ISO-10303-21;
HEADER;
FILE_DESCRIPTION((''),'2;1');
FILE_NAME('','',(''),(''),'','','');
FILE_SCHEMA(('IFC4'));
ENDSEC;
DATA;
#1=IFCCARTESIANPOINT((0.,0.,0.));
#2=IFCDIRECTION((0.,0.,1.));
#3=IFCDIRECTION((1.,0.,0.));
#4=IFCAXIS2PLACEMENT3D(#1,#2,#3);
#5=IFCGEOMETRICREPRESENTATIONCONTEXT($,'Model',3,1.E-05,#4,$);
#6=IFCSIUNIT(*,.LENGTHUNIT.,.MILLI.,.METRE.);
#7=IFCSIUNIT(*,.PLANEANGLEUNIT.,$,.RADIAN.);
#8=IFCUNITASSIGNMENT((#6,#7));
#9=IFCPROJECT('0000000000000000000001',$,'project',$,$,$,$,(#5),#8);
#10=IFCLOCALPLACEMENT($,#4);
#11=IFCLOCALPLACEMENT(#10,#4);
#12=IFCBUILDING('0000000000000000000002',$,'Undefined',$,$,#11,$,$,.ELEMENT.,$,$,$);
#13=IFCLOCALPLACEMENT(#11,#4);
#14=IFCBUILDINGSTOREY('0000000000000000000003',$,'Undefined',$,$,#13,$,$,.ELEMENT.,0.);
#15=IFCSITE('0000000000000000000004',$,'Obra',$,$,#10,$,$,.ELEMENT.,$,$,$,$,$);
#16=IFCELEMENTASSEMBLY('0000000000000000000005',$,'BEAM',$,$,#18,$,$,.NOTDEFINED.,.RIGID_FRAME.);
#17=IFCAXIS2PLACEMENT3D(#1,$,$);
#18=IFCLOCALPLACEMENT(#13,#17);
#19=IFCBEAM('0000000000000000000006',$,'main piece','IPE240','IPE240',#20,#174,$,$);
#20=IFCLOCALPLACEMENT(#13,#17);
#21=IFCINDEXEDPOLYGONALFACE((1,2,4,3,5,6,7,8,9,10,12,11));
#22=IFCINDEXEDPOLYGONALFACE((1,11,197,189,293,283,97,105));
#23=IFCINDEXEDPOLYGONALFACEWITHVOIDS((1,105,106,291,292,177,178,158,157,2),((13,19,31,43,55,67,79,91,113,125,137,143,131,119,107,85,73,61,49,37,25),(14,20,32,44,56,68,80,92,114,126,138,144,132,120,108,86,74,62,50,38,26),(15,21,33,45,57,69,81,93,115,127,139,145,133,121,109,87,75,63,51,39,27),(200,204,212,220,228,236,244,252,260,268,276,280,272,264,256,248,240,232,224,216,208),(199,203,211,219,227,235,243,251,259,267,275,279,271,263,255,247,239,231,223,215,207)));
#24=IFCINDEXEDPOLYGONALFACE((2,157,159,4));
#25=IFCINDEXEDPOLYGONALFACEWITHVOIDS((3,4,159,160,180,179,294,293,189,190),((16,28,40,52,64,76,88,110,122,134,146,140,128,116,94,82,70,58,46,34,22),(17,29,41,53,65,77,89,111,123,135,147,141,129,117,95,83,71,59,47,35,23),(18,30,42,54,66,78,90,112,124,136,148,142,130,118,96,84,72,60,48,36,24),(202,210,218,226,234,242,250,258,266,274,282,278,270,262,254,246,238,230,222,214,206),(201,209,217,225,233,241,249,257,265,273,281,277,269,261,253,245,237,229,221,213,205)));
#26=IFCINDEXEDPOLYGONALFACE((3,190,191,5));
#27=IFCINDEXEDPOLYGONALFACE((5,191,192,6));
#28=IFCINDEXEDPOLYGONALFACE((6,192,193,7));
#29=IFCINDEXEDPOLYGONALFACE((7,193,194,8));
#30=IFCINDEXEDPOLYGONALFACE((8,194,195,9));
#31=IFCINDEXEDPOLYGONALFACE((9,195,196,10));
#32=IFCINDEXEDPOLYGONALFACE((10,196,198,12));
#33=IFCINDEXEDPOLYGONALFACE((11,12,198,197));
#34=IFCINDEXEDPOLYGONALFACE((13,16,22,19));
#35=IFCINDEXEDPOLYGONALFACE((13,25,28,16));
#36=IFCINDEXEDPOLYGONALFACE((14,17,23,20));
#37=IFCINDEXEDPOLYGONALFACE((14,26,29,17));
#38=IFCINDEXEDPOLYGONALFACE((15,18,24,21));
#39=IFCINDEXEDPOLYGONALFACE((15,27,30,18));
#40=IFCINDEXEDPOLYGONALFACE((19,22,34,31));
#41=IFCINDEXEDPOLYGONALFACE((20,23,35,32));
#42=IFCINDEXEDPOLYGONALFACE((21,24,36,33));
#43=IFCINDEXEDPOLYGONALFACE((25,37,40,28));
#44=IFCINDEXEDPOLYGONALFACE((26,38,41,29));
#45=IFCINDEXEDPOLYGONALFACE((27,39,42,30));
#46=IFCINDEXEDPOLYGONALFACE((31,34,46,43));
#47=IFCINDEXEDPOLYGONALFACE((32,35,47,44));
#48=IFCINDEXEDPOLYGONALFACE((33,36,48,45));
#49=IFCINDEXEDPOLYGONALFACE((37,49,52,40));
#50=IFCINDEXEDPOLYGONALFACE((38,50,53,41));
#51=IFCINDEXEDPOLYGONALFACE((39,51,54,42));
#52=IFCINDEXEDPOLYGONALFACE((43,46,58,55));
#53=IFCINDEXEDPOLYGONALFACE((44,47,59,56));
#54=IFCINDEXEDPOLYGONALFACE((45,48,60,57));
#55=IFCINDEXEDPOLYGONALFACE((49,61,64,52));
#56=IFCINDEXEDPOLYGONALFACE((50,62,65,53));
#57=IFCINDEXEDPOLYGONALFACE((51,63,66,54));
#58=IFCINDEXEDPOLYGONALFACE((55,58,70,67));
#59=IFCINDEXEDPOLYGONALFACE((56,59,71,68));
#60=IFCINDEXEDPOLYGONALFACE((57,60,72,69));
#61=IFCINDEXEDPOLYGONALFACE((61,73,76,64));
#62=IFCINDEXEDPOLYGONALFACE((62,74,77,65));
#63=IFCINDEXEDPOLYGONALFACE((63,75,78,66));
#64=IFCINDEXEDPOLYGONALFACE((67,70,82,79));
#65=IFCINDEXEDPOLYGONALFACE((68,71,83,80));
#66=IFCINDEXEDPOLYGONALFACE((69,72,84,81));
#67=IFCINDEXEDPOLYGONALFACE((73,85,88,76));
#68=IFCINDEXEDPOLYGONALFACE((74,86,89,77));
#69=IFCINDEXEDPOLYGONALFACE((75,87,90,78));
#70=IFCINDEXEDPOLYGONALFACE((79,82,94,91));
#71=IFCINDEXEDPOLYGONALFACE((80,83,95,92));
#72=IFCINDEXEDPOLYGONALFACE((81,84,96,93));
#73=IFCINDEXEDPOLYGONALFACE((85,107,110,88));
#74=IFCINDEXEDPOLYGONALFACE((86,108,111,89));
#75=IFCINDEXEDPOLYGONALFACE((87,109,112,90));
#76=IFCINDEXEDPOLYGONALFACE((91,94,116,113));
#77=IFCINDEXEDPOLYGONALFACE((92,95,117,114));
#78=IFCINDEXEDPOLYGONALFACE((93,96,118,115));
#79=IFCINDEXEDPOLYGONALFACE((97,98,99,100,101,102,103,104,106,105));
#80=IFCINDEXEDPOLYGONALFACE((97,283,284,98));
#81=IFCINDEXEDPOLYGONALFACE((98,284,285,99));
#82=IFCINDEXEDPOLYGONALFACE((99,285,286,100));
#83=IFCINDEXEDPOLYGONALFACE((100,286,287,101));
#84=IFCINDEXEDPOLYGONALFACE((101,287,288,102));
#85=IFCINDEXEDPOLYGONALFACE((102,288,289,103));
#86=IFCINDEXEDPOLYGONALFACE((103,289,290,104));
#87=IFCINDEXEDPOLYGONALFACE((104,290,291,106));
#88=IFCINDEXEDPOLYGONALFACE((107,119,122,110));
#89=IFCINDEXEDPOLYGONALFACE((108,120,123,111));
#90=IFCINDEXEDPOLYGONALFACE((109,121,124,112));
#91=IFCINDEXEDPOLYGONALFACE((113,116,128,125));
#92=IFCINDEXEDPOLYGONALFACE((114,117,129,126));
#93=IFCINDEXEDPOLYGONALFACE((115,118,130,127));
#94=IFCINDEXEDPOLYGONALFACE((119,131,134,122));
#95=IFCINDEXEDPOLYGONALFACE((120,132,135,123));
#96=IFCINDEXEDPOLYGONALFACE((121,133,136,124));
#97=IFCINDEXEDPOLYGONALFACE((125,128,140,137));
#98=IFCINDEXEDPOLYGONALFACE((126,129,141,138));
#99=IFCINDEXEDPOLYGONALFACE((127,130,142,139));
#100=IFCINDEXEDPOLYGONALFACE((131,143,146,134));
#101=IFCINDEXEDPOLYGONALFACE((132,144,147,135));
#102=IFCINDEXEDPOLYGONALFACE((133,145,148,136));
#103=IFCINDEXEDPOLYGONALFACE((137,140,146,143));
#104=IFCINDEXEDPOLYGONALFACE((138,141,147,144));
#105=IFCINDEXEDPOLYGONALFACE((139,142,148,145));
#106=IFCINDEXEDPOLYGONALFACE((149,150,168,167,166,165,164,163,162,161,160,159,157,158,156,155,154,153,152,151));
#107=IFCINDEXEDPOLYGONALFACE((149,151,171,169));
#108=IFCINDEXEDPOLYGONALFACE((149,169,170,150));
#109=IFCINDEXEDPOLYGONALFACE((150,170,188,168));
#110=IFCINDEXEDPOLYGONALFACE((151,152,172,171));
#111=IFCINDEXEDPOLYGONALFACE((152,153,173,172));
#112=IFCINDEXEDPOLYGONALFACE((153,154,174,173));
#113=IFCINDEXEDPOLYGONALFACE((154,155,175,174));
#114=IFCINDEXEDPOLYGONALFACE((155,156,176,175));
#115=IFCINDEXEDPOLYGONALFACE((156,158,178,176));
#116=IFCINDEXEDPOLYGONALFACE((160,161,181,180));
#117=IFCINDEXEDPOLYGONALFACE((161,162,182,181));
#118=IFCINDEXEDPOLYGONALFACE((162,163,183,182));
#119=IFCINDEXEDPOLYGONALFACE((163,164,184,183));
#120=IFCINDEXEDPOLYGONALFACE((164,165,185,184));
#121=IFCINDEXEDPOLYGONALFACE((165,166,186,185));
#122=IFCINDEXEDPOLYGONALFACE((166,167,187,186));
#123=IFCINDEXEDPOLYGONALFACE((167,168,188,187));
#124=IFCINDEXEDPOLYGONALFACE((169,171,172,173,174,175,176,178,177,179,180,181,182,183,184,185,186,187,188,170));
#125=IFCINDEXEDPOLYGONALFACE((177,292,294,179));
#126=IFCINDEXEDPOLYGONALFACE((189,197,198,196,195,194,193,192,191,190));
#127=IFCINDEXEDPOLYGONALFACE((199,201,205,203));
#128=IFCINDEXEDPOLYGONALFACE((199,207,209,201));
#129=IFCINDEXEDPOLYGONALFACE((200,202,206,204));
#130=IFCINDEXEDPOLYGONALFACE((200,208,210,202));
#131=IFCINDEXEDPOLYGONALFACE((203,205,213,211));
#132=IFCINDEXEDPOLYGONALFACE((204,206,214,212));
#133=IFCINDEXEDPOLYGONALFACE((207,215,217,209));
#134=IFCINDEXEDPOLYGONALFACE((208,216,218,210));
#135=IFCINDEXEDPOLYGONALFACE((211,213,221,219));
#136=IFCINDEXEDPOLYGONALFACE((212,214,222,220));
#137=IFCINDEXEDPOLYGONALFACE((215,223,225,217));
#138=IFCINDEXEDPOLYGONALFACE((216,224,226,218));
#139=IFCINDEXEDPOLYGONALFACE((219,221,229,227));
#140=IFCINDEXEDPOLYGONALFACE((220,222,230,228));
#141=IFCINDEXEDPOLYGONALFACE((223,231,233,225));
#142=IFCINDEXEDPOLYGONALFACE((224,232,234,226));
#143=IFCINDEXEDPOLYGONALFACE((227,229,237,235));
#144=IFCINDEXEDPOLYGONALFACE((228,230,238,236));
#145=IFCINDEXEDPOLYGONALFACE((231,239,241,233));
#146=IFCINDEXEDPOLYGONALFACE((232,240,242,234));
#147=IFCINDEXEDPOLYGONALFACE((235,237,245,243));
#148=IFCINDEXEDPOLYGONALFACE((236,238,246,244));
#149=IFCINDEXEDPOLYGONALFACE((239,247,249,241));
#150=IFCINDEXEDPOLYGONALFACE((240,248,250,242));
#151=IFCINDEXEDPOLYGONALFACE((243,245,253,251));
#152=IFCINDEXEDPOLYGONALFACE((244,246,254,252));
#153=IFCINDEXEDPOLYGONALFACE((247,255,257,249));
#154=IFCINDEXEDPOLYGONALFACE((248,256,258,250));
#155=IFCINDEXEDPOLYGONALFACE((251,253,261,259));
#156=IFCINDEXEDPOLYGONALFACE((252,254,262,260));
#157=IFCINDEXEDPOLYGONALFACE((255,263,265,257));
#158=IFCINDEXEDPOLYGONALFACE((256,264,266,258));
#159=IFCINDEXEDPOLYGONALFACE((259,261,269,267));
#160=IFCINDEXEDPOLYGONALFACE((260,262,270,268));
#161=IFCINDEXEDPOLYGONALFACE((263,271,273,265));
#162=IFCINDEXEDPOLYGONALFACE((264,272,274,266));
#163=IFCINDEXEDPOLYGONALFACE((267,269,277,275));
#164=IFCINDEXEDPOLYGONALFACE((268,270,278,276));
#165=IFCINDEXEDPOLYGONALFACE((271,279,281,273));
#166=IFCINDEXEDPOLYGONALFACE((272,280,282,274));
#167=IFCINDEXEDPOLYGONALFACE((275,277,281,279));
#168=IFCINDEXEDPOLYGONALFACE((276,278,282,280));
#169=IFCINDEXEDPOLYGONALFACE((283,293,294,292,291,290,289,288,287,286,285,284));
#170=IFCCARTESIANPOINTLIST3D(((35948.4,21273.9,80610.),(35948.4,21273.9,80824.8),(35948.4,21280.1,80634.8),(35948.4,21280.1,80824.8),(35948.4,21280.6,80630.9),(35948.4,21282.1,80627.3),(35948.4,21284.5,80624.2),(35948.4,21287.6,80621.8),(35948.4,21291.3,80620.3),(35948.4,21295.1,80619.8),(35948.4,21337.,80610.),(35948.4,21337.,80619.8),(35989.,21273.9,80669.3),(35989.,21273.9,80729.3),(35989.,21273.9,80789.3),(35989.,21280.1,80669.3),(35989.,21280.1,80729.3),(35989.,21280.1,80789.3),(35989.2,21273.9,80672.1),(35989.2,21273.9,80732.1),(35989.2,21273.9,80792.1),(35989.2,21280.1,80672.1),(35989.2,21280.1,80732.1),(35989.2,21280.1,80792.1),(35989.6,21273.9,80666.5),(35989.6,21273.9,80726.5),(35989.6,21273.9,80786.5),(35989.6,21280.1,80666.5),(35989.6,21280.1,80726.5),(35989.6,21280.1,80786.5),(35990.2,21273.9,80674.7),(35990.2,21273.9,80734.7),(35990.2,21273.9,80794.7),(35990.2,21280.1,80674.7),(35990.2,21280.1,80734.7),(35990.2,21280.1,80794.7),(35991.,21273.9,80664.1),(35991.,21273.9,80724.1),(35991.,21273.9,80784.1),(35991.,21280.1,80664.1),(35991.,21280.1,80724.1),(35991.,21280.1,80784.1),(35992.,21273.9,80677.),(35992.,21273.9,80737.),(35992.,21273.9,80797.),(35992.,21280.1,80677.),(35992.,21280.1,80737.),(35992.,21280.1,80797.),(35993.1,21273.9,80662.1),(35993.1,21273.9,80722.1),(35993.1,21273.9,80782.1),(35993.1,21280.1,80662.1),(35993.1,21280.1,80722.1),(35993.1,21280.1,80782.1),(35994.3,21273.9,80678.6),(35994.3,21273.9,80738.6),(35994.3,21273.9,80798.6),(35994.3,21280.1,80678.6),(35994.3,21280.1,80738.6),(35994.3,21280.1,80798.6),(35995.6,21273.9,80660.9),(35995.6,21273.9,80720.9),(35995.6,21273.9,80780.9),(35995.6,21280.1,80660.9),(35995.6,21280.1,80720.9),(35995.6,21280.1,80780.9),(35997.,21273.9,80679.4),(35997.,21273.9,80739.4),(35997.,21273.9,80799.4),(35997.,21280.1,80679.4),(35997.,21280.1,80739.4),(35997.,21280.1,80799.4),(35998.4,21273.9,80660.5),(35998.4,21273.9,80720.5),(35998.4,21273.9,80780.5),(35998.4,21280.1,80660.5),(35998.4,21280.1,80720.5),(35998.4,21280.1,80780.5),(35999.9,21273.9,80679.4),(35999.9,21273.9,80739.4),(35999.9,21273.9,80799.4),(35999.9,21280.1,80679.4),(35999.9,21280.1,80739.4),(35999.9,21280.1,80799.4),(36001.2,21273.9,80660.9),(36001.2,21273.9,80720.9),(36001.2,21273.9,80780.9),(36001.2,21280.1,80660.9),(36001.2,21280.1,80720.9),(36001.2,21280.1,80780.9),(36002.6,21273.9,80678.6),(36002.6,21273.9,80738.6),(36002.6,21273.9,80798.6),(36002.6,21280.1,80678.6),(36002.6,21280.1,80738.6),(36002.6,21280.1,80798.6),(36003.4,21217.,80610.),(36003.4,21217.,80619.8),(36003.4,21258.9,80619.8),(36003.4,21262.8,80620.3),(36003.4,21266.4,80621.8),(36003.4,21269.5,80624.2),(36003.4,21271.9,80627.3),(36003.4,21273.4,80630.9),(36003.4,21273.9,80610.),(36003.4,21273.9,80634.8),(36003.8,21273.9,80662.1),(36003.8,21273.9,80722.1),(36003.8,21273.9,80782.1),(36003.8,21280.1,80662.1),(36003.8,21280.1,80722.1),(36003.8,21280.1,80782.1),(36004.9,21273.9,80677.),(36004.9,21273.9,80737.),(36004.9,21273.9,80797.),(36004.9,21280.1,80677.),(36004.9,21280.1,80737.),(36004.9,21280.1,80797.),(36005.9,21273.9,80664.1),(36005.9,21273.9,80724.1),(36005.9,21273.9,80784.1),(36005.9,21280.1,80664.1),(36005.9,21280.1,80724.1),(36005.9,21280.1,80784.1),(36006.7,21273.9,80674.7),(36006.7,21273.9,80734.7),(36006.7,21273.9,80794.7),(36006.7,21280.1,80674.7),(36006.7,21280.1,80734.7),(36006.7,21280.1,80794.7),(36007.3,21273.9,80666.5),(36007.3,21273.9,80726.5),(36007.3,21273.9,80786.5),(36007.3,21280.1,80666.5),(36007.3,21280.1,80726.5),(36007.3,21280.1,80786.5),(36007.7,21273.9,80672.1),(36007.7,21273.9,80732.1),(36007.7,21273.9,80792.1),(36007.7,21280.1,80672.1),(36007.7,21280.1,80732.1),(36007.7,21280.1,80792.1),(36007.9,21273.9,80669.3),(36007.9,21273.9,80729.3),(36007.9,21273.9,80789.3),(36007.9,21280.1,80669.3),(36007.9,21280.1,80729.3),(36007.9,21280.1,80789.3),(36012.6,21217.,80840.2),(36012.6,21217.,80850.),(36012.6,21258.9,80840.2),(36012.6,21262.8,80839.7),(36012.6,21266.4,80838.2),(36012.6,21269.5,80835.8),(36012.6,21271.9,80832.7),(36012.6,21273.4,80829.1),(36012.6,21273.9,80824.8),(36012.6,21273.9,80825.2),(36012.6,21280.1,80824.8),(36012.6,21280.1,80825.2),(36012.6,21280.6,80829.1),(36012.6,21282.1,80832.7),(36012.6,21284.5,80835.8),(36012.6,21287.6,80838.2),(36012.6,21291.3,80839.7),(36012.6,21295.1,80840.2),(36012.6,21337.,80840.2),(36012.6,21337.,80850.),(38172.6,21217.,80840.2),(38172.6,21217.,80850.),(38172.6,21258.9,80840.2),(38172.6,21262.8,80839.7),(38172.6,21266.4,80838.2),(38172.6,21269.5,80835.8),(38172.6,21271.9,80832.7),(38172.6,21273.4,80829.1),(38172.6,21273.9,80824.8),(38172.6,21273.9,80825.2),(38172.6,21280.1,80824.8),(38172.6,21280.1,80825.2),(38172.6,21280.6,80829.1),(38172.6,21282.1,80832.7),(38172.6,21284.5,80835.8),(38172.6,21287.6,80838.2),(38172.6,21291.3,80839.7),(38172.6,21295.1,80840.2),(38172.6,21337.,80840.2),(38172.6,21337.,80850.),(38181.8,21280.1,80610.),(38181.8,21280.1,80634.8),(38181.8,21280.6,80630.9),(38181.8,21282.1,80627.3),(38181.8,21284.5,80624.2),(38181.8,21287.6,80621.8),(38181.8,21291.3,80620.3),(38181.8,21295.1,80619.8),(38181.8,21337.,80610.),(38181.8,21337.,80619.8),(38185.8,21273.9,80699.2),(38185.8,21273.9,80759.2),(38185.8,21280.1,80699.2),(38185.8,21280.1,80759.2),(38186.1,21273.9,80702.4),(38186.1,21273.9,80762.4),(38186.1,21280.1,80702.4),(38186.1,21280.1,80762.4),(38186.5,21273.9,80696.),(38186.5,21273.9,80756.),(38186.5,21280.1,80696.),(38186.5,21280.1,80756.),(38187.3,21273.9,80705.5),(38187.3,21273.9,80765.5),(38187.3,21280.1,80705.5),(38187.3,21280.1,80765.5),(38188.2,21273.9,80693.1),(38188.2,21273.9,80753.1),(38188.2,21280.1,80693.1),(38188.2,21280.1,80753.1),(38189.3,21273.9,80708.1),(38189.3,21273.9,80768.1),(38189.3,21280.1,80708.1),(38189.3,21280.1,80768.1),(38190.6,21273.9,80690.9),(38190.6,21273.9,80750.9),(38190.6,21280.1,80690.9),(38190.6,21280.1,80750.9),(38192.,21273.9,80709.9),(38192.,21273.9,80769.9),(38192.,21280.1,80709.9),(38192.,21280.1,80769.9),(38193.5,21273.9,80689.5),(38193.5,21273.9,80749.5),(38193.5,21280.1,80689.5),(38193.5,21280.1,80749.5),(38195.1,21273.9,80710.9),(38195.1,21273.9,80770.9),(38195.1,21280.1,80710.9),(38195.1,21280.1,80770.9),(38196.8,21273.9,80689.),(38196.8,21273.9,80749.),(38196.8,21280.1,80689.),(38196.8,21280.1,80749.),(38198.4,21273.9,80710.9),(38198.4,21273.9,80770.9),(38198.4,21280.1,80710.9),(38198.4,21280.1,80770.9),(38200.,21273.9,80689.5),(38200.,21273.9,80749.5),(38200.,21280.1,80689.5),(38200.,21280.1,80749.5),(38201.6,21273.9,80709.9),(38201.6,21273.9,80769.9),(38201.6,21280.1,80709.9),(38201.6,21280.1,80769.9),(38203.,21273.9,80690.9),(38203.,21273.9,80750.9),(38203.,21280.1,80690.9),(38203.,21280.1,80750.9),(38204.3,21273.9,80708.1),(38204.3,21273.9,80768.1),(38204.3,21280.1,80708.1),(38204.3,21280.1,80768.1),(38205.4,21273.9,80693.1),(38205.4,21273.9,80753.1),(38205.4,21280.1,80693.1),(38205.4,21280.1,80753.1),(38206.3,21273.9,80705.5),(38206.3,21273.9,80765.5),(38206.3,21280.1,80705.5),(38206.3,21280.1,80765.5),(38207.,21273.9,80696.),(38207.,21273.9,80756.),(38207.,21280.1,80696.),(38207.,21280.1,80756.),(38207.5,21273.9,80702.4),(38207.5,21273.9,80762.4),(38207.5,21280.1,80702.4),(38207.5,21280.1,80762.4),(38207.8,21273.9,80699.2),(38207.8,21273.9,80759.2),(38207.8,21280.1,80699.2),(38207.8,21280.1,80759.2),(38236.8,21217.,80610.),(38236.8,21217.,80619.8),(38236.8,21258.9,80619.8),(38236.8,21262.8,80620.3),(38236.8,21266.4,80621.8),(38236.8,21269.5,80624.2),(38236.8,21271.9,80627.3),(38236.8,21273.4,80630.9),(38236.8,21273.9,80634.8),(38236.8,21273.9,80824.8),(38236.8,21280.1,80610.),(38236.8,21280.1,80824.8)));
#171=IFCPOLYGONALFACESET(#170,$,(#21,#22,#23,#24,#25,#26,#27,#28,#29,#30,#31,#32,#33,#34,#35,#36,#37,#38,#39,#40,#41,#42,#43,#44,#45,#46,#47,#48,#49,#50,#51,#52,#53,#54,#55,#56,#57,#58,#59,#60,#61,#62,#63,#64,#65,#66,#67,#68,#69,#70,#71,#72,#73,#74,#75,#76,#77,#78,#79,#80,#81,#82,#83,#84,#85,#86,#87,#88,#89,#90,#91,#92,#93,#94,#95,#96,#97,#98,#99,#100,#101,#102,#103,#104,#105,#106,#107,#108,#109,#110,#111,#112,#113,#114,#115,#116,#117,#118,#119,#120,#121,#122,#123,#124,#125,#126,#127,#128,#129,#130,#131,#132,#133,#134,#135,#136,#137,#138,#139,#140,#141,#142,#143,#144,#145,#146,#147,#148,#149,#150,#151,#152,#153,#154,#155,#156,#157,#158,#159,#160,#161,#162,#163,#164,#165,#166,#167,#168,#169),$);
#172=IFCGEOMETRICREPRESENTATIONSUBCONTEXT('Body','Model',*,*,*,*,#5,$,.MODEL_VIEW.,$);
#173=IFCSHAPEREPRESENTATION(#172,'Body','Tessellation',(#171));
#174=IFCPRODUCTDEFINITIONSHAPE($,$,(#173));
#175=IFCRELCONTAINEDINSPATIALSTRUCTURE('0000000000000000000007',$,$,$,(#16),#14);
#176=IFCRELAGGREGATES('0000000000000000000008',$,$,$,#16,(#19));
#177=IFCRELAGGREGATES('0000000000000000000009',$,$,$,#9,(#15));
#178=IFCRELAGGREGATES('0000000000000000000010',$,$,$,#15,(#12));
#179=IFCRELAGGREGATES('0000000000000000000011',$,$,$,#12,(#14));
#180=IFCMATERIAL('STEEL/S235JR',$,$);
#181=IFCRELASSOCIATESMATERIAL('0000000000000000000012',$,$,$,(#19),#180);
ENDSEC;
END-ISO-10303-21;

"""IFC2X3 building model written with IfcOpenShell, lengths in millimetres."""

from ifc_helpers import new_model, si_unit, frame, origin_with_axes, origin_2d_with_axis, place, context, subcontext, project, spatial, rectangle, circle, i_section, extrude, clip, halfspace, source, transform, mapped, material, element, aggregate, save


model = new_model("IFC2X3")

# Units and contexts
model_context = context("Model", 3, precision=1e-05, world=origin_with_axes())
body_context = subcontext(model_context, "Body", "Model", "MODEL_VIEW")
ifc_project = project(units=[si_unit("LENGTHUNIT", "METRE", prefix="MILLI"), si_unit("PLANEANGLEUNIT", "RADIAN")], contexts=[model_context])

# Site, building, storey
site_placement = place(None, origin_with_axes())
site = spatial("IfcSite", under=ifc_project, at=site_placement, Name="Obra", CompositionType="ELEMENT")
building_placement = place(site_placement, origin_with_axes())
building = spatial("IfcBuilding", under=site, at=building_placement, Name="Undefined", CompositionType="ELEMENT")
storey_placement = place(building_placement, origin_with_axes())
storey = spatial("IfcBuildingStorey", under=building, at=storey_placement, Name="Undefined", CompositionType="ELEMENT", Elevation=0.0)

# Element assembly, beam, openings
assembly_1_placement = place(storey_placement, origin_with_axes())
assembly_1 = element("IfcElementAssembly", 1, at=assembly_1_placement, inside=storey, Name="BEAM", AssemblyPlace="NOTDEFINED", PredefinedType="RIGID_FRAME")
ifc_material_1 = material(Name="STEEL/S235JR")
beam_1_placement = place(assembly_1_placement, frame((36015.4, 21277.0, 80730.0), z_axis=(0.0, 0.0, 1.0), x_axis=(1.0, 0.0, 0.0)))
beam_1 = element("IfcBeam", 2, at=beam_1_placement, material=ifc_material_1, Name="main piece", Description="IPE240", ObjectType="IPE240", context=body_context, shape_type="Clipping", body=[
    clip(clip(extrude(i_section(OverallWidth=120.0, OverallDepth=240.0, WebThickness=6.2, FlangeThickness=9.8, FilletRadius=15.0, at=origin_2d_with_axis()), frame((2221.4, 0.0, 0.0), z_axis=(-1.0, 0.0, 0.0), x_axis=(0.0, -1.0, 0.0)), (0.0, 0.0, 1.0), 2288.3), halfspace(frame((2221.4, 0.0, -220.0), z_axis=(-1.0, 0.0, 0.0), x_axis=(0.0, 1.0, 0.0)), True)), halfspace(frame((-66.9, 0.0, -220.0), z_axis=(1.0, 0.0, 0.0), x_axis=(0.0, -1.0, 0.0)), True)),
])
opening_1_placement = place(assembly_1_placement, frame((36015.4, 21277.0, 80730.0), z_axis=(0.0, 0.0, 1.0), x_axis=(1.0, 0.0, 0.0)))
element("IfcOpeningElement", 3, at=opening_1_placement, cuts=beam_1, ObjectType="Recess", context=body_context, shape_type="SweptSolid", body=[
    extrude(rectangle(XDim=65.0, YDim=300.0, at=origin_2d_with_axis()), frame((2198.9, 153.1, 109.8), z_axis=(0.0, 0.0, -1.0), x_axis=(-1.0, 0.0, 0.0)), (0.0, 0.0, 1.0), 249.6),
])
opening_2_placement = place(assembly_1_placement, frame((36015.4, 21277.0, 80730.0), z_axis=(0.0, 0.0, 1.0), x_axis=(1.0, 0.0, 0.0)))
element("IfcOpeningElement", 4, at=opening_2_placement, cuts=beam_1, ObjectType="Recess", context=body_context, shape_type="SweptSolid", body=[
    extrude(rectangle(XDim=26.2, YDim=76.2, at=origin_2d_with_axis()), frame((2195.3, 61.0, 107.9), z_axis=(0.0, -1.0, 0.0), x_axis=(0.0, 0.0, -1.0)), (0.0, 0.0, 1.0), 122.0),
])
opening_3_placement = place(assembly_1_placement, frame((36015.4, 21277.0, 80730.0), z_axis=(0.0, 0.0, 1.0), x_axis=(1.0, 0.0, 0.0)))
element("IfcOpeningElement", 5, at=opening_3_placement, cuts=beam_1, ObjectType="Recess", context=body_context, shape_type="SweptSolid", body=[
    extrude(rectangle(XDim=65.0, YDim=300.0, at=origin_2d_with_axis()), frame((-44.4, -153.1, 109.8), z_axis=(0.0, 0.0, -1.0), x_axis=(1.0, 0.0, 0.0)), (0.0, 0.0, 1.0), 249.6),
])
opening_4_placement = place(assembly_1_placement, frame((36015.4, 21277.0, 80730.0), z_axis=(0.0, 0.0, 1.0), x_axis=(1.0, 0.0, 0.0)))
element("IfcOpeningElement", 6, at=opening_4_placement, cuts=beam_1, ObjectType="Recess", context=body_context, shape_type="SweptSolid", body=[
    extrude(rectangle(XDim=26.2, YDim=76.2, at=origin_2d_with_axis()), frame((-40.8, -61.0, 107.9), z_axis=(0.0, 1.0, 0.0), x_axis=(0.0, 0.0, -1.0)), (0.0, 0.0, 1.0), 122.0),
])
shared_shape_1 = source(origin_with_axes(), body_context, "Body", "SweptSolid", [
    extrude(circle(Radius=11.0, at=origin_2d_with_axis()), frame((0.0, -3.2, 0.0), z_axis=(0.0, 1.0, 0.0), x_axis=(1.0, 0.0, 0.0)), (0.0, 0.0, 1.0), 6.4),
])
opening_5_placement = place(assembly_1_placement, frame((38236.8, 21277.0, 80850.0), z_axis=(-1.0, 0.0, 0.0), x_axis=(0.0, 0.0, -1.0)))
element("IfcOpeningElement", 7, at=opening_5_placement, cuts=beam_1, ObjectType="Opening", context=body_context, shape_type="MappedRepresentation", body=[
    mapped(shared_shape_1, transform((90.0, 0.0, 40.0))),
    mapped(shared_shape_1, transform((150.0, 0.0, 40.0))),
])
shared_shape_2 = source(origin_with_axes(), body_context, "Body", "SweptSolid", [
    extrude(circle(Radius=9.5, at=origin_2d_with_axis()), frame((0.0, -3.2, 0.0), z_axis=(0.0, 1.0, 0.0), x_axis=(1.0, 0.0, 0.0)), (0.0, 0.0, 1.0), 6.4),
])
opening_6_placement = place(assembly_1_placement, frame((35948.4, 21277.0, 80850.0), z_axis=(1.0, 0.0, 0.0), x_axis=(0.0, 0.0, -1.0)))
element("IfcOpeningElement", 8, at=opening_6_placement, cuts=beam_1, ObjectType="Opening", context=body_context, shape_type="MappedRepresentation", body=[
    mapped(shared_shape_2, transform((60.0, 0.0, 50.0))),
    mapped(shared_shape_2, transform((120.0, 0.0, 50.0))),
    mapped(shared_shape_2, transform((180.0, 0.0, 50.0))),
])
aggregate(assembly_1, [beam_1])

save(model, "model.ifc")
